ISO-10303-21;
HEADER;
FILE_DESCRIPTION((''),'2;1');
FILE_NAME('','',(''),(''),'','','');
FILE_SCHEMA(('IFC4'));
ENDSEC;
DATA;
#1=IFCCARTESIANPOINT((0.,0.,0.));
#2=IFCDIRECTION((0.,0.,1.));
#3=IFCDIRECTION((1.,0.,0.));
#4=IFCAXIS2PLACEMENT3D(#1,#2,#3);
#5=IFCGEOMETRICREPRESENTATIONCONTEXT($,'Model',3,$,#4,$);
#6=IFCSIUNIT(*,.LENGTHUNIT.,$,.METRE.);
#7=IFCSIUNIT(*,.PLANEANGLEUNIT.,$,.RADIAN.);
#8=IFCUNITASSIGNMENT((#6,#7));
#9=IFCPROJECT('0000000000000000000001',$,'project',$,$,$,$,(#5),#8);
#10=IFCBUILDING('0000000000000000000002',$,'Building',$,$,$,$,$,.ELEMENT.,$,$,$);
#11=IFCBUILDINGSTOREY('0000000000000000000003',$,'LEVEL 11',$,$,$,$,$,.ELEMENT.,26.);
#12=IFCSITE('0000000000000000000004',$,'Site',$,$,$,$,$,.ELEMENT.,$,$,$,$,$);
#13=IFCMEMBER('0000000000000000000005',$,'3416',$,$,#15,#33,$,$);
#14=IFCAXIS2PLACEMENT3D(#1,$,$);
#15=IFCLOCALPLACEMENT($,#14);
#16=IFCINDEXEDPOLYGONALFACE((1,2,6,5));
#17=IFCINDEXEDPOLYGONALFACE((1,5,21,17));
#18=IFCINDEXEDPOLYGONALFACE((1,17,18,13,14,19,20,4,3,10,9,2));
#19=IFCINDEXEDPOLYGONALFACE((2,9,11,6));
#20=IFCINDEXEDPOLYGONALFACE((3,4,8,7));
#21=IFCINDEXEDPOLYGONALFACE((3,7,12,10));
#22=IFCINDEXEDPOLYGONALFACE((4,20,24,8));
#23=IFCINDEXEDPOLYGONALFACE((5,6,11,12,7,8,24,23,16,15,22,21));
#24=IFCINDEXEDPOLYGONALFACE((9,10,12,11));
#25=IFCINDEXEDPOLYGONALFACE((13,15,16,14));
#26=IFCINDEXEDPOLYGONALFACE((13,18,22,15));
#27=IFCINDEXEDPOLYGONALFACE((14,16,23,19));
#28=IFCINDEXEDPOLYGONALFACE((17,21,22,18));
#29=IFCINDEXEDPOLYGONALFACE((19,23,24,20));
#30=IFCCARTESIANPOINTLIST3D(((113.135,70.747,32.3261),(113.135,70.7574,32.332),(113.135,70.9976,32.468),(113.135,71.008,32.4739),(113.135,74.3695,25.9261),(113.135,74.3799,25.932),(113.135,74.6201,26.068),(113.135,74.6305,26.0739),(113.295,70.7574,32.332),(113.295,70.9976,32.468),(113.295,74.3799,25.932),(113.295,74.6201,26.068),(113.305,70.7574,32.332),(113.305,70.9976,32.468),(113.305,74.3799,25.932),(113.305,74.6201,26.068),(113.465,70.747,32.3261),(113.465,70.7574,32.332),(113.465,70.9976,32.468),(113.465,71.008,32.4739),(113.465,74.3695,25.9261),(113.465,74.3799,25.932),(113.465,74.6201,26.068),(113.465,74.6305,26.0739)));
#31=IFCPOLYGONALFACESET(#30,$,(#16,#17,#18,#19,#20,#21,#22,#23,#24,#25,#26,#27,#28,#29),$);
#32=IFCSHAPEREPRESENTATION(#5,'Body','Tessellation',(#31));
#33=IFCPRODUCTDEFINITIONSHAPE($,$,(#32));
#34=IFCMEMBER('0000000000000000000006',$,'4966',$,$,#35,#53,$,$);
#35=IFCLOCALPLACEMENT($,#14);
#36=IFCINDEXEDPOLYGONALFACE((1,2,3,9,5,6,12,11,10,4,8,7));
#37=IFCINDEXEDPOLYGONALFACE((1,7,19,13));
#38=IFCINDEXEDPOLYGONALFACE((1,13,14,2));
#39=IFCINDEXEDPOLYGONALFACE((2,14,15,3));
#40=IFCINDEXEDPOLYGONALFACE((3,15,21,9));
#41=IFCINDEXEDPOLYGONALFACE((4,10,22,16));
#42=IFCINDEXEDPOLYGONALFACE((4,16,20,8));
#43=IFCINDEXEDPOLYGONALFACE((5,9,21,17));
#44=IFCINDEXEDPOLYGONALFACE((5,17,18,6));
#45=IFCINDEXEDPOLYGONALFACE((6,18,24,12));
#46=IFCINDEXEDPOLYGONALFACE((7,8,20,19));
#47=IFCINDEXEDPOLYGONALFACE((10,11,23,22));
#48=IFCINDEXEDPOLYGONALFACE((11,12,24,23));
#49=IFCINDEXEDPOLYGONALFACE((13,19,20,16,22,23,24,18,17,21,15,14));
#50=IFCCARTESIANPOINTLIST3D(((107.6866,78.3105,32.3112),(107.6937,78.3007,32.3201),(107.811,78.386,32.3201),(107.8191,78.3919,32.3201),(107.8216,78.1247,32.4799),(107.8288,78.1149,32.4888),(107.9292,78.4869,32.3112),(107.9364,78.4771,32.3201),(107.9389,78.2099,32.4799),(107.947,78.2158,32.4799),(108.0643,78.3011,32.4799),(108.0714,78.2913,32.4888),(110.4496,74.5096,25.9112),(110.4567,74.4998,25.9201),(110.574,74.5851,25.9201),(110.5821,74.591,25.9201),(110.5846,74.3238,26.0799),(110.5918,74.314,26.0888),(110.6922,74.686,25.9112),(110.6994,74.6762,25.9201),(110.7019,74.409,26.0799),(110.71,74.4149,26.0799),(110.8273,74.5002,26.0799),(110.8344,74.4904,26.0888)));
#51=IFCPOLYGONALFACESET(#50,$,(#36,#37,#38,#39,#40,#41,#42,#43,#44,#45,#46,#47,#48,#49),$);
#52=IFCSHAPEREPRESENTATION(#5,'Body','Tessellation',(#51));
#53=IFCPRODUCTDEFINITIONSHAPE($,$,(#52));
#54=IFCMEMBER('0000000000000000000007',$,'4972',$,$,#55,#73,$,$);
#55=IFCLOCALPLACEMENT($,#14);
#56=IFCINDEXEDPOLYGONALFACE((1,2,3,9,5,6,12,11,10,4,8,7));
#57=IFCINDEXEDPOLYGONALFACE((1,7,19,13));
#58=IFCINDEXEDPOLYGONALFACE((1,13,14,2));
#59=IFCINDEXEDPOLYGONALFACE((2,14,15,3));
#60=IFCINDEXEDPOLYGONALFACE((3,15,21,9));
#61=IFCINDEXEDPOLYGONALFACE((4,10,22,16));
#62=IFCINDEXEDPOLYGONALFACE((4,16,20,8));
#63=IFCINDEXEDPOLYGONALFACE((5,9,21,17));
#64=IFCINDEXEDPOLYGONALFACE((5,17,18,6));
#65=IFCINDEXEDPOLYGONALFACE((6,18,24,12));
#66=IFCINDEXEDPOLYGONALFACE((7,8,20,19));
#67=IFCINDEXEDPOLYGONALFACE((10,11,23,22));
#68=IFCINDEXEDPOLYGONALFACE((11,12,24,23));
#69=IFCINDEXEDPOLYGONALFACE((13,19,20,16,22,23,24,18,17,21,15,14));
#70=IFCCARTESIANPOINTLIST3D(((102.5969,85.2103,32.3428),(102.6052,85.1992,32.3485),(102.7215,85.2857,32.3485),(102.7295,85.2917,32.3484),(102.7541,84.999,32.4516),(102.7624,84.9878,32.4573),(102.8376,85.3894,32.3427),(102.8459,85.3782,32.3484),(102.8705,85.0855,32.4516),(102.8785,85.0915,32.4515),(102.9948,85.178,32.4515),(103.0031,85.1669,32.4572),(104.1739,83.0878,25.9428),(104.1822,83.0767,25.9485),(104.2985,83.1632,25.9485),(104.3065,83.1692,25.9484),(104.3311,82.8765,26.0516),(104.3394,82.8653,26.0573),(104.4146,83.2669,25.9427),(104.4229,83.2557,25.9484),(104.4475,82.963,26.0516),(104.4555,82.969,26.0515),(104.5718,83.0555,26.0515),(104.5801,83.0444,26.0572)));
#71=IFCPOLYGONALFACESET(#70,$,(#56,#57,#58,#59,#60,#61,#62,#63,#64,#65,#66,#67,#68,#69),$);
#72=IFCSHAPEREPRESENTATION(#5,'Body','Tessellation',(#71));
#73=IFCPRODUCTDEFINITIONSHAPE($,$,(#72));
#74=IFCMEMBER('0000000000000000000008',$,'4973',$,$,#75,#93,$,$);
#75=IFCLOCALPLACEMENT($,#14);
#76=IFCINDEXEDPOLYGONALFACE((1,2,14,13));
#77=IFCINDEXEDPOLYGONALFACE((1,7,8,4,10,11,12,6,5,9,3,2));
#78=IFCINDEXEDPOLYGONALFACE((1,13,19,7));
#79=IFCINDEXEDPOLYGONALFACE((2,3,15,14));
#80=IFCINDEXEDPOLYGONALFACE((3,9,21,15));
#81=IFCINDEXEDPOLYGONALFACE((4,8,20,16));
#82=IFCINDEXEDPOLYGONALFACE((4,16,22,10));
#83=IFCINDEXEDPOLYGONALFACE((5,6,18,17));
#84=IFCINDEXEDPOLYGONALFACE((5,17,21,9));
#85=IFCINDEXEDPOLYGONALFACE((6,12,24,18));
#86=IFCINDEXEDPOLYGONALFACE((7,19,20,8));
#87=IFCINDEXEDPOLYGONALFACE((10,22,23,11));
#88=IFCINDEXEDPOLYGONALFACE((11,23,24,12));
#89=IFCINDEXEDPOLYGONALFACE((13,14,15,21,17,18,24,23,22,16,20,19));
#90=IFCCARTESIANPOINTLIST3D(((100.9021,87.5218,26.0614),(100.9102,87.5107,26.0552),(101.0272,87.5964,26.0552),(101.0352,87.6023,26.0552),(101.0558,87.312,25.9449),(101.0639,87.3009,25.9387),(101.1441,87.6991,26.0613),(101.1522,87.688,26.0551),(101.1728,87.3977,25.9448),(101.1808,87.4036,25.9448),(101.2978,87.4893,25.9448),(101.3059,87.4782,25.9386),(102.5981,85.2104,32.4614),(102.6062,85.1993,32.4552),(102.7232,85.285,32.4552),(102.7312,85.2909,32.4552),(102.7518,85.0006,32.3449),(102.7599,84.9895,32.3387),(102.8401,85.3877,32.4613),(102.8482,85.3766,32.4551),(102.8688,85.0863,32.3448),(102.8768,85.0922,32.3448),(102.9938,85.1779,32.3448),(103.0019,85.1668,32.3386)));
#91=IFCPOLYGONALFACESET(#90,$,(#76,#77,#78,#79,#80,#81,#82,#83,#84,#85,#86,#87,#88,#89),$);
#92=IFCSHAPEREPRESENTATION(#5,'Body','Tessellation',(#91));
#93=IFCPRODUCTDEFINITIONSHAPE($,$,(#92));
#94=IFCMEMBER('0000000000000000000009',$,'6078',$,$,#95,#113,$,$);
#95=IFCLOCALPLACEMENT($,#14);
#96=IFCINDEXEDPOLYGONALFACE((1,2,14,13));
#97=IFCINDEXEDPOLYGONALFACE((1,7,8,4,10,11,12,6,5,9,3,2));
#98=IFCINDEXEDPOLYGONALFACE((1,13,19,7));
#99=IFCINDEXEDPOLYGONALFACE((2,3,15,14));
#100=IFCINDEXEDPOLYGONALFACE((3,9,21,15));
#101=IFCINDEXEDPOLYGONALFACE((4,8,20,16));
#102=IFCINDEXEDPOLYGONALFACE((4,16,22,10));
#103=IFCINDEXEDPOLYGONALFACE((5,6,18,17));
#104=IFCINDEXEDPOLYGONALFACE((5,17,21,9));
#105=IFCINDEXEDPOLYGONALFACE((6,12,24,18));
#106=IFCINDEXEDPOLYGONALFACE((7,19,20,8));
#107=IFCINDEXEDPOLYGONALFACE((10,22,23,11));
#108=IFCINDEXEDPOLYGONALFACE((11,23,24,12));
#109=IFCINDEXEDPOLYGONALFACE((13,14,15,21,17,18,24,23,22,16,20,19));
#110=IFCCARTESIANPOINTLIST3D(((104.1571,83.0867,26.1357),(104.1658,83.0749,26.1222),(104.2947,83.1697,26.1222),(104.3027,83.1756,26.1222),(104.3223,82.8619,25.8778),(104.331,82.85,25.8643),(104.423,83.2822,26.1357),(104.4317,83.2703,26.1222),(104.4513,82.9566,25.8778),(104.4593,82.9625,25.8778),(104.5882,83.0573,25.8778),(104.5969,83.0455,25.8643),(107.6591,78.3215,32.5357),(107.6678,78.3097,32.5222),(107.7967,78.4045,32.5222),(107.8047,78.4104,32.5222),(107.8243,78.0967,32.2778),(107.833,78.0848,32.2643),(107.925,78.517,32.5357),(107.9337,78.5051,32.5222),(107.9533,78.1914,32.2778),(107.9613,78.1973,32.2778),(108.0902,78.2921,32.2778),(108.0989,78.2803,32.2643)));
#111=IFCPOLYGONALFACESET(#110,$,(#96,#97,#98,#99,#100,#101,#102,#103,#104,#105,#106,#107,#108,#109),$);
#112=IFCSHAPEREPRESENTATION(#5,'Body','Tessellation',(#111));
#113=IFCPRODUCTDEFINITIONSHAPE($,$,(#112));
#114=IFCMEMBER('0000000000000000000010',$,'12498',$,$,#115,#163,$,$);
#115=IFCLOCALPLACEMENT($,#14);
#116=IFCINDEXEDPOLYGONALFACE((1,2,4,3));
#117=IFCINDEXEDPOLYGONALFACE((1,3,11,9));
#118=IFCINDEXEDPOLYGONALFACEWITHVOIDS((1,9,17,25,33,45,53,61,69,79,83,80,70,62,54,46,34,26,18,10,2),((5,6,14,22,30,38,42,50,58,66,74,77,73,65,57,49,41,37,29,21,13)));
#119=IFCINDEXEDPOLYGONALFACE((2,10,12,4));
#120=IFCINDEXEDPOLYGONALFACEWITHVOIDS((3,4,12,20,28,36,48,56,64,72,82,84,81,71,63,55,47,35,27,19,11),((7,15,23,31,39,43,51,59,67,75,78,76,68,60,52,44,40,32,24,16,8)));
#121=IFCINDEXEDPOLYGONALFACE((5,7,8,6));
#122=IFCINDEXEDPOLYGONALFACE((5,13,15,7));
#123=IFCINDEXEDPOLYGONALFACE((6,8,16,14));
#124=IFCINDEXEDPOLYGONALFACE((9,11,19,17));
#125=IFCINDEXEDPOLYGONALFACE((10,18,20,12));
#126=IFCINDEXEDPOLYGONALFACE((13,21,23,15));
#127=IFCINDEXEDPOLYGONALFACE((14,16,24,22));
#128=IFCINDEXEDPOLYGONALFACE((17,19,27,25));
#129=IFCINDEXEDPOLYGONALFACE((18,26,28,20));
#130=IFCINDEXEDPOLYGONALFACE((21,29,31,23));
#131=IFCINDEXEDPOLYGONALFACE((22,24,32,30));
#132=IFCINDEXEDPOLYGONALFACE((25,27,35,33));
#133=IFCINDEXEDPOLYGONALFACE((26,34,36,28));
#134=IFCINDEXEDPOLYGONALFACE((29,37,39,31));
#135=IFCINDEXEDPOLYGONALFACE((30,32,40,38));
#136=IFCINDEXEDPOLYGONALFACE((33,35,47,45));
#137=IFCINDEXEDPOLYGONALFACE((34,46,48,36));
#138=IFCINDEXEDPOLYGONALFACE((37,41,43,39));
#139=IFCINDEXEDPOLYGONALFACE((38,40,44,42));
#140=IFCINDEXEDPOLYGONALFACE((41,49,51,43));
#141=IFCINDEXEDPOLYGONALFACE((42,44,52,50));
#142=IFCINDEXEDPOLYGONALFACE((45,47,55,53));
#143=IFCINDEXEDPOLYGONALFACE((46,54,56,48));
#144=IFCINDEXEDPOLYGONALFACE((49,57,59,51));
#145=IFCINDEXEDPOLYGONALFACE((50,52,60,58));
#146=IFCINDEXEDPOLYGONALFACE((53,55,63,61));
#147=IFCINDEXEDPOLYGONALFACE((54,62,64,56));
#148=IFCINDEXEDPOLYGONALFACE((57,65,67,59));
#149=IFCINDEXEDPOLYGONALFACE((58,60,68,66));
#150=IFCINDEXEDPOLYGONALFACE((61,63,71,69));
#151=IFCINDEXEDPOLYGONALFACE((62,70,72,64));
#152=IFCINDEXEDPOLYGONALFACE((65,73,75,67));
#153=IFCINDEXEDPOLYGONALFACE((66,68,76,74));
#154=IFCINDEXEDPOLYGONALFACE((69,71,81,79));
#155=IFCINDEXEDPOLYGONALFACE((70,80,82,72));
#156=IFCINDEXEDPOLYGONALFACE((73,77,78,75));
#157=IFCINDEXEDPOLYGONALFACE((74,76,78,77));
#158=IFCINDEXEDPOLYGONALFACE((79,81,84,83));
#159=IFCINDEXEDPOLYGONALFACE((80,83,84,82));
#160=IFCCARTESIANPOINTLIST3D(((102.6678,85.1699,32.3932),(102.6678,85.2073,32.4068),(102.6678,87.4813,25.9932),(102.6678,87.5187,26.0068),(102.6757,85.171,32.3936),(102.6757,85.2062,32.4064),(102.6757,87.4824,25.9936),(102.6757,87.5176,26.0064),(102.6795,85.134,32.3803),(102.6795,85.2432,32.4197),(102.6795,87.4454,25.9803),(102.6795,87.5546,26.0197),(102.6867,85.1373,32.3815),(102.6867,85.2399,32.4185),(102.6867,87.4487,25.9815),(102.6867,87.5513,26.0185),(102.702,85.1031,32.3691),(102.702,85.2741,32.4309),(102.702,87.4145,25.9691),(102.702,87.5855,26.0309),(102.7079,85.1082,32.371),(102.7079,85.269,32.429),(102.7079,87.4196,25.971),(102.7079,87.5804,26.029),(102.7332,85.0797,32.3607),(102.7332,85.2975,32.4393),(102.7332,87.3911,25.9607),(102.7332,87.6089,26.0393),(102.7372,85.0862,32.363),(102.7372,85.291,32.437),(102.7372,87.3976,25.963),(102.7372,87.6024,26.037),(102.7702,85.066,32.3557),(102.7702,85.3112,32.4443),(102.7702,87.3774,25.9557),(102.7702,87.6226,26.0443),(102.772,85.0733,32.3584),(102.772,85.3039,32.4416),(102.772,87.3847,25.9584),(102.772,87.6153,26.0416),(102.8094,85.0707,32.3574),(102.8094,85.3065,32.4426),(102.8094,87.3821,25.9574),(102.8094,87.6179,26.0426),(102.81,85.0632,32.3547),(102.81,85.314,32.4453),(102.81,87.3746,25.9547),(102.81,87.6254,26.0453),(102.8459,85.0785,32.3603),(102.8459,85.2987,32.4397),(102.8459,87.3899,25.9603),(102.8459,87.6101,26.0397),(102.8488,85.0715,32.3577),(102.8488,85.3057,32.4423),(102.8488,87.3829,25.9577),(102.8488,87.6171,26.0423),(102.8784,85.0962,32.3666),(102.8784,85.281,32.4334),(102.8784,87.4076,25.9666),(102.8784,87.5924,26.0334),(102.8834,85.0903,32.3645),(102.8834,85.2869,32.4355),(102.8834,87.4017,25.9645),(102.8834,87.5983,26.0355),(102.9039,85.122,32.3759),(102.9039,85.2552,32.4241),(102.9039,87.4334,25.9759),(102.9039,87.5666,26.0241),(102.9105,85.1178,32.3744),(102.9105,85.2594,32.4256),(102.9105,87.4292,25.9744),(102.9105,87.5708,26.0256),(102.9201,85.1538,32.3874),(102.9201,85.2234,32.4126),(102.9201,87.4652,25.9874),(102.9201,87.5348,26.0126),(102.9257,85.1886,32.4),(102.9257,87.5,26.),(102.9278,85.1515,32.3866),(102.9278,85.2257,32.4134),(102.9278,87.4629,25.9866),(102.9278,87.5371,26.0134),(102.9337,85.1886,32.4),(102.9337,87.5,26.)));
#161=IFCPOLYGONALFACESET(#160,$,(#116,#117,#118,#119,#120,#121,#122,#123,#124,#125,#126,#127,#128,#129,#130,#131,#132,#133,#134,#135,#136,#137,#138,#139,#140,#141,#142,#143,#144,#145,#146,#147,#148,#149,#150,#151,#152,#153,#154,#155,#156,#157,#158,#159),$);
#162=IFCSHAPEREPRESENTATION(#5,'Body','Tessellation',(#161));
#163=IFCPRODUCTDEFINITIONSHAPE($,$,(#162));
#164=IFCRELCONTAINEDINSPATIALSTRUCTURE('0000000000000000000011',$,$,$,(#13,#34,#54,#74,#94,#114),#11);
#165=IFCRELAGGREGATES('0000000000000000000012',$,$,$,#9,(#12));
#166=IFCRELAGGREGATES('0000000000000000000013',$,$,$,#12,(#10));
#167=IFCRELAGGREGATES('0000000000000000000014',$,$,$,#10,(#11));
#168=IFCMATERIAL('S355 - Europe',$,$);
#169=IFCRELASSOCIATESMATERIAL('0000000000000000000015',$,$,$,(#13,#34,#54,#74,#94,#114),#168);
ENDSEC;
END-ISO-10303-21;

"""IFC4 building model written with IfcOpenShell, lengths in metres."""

from ifc_helpers import new_model, si_unit, frame, origin_with_axes, origin_2d_with_axis, place, context, project, spatial, hollow_circle, i_section, extrude, material, material_profile, profile_set, profile_usage, element, save


model = new_model("IFC4")

# Units and contexts
model_context = context("Model", 3, world=origin_with_axes())
ifc_project = project(units=[si_unit("LENGTHUNIT", "METRE"), si_unit("PLANEANGLEUNIT", "RADIAN")], contexts=[model_context])

# Site, building, storey
site = spatial("IfcSite", under=ifc_project, Name="Site", CompositionType="ELEMENT")
building = spatial("IfcBuilding", under=site, Name="Building", CompositionType="ELEMENT")
storey = spatial("IfcBuildingStorey", under=building, Name="LEVEL 11", CompositionType="ELEMENT", Elevation=26.0)

# Shared definitions
ifc_material = material(Name="S355 - Europe")

# Members
ifc_material_profile_1 = material_profile(ifc_material, i_section(OverallWidth=0.33, OverallDepth=0.3, WebThickness=0.01, FlangeThickness=0.012, at=origin_2d_with_axis()))
ifc_profile_set_1 = profile_set([ifc_material_profile_1])
ifc_profile_usage_1 = profile_usage(ifc_profile_set_1, cardinal=10)
member_1_placement = place(None, frame((113.3, 74.5, 26.0), z_axis=(0.0, -0.492584, 0.870265), x_axis=(1.0, 0.0, 0.0)))
element("IfcMember", 1, at=member_1_placement, inside=storey, material=ifc_profile_usage_1, Name="3416", context=model_context, shape_type="SweptSolid", body=[
    extrude(i_section(OverallWidth=0.33, OverallDepth=0.3, WebThickness=0.01, FlangeThickness=0.012, at=origin_2d_with_axis()), origin_with_axes(), (0.0, 0.0, 1.0), 7.3541),
])
ifc_material_profile_2 = material_profile(ifc_material, i_section(OverallWidth=0.3, OverallDepth=0.3, WebThickness=0.01, FlangeThickness=0.015, at=origin_2d_with_axis()))
ifc_profile_set_2 = profile_set([ifc_material_profile_2])
ifc_profile_usage_2 = profile_usage(ifc_profile_set_2, cardinal=10)
member_2_placement = place(None, frame((110.642, 74.5, 26.0), z_axis=(-0.347992, 0.478713, 0.806062), x_axis=(-0.808912, -0.587929, 0.0)))
element("IfcMember", 2, at=member_2_placement, inside=storey, material=ifc_profile_usage_2, Name="4966", context=model_context, shape_type="SweptSolid", body=[
    extrude(i_section(OverallWidth=0.3, OverallDepth=0.3, WebThickness=0.01, FlangeThickness=0.015, at=origin_2d_with_axis()), origin_with_axes(), (0.0, 0.0, 1.0), 7.9398),
])
ifc_material_profile_3 = material_profile(ifc_material, i_section(OverallWidth=0.3, OverallDepth=0.3, WebThickness=0.01, FlangeThickness=0.015, at=origin_2d_with_axis()))
ifc_profile_set_3 = profile_set([ifc_material_profile_3])
ifc_profile_usage_3 = profile_usage(ifc_profile_set_3, cardinal=10)
member_3_placement = place(None, frame((104.377, 83.0661, 26.0), z_axis=(-0.227734, 0.30651, 0.924223), x_axis=(-0.802364, -0.596835, 0.0)))
element("IfcMember", 3, at=member_3_placement, inside=storey, material=ifc_profile_usage_3, Name="4972", context=model_context, shape_type="SweptSolid", body=[
    extrude(i_section(OverallWidth=0.3, OverallDepth=0.3, WebThickness=0.01, FlangeThickness=0.015, at=origin_2d_with_axis()), origin_with_axes(), (0.0, 0.0, 1.0), 6.9247),
])
ifc_material_profile_4 = material_profile(ifc_material, i_section(OverallWidth=0.3, OverallDepth=0.3, WebThickness=0.01, FlangeThickness=0.015, at=origin_2d_with_axis()))
ifc_profile_set_4 = profile_set([ifc_material_profile_4])
ifc_profile_usage_4 = profile_usage(ifc_profile_set_4, cardinal=10)
member_4_placement = place(None, frame((102.8, 85.1886, 32.4), z_axis=(-0.241844, 0.329599, -0.91262), x_axis=(-0.806706, -0.590953, 0.0)))
element("IfcMember", 4, at=member_4_placement, inside=storey, material=ifc_profile_usage_4, Name="4973", context=model_context, shape_type="SweptSolid", body=[
    extrude(i_section(OverallWidth=0.3, OverallDepth=0.3, WebThickness=0.01, FlangeThickness=0.015, at=origin_2d_with_axis()), origin_with_axes(), (0.0, 0.0, 1.0), 7.0128),
])
ifc_material_profile_5 = material_profile(ifc_material, i_section(OverallWidth=0.33, OverallDepth=0.4, WebThickness=0.01, FlangeThickness=0.02, at=origin_2d_with_axis()))
ifc_profile_set_5 = profile_set([ifc_material_profile_5])
ifc_profile_usage_5 = profile_usage(ifc_profile_set_5, cardinal=10)
member_5_placement = place(None, frame((107.879, 78.3009, 32.4), z_axis=(-0.401889, 0.546854, -0.734463), x_axis=(-0.805765, -0.592235, 0.0)))
element("IfcMember", 5, at=member_5_placement, inside=storey, material=ifc_profile_usage_5, Name="6078", context=model_context, shape_type="SweptSolid", body=[
    extrude(i_section(OverallWidth=0.33, OverallDepth=0.4, WebThickness=0.01, FlangeThickness=0.02, at=origin_2d_with_axis()), origin_with_axes(), (0.0, 0.0, 1.0), 8.7138),
])
ifc_material_profile_6 = material_profile(ifc_material, hollow_circle(Radius=0.1337, WallThickness=0.008, at=origin_2d_with_axis()))
ifc_profile_set_6 = profile_set([ifc_material_profile_6])
ifc_profile_usage_6 = profile_usage(ifc_profile_set_6, cardinal=10)
member_6_placement = place(None, frame((102.8, 87.5, 26.0), z_axis=(0.0, -0.339682, 0.94054), x_axis=(1.0, 0.0, 0.0)))
element("IfcMember", 6, at=member_6_placement, inside=storey, material=ifc_profile_usage_6, Name="12498", context=model_context, shape_type="SweptSolid", body=[
    extrude(hollow_circle(Radius=0.1337, WallThickness=0.008, at=origin_2d_with_axis()), origin_with_axes(), (0.0, 0.0, 1.0), 6.8046),
])

save(model, "model.ifc")
